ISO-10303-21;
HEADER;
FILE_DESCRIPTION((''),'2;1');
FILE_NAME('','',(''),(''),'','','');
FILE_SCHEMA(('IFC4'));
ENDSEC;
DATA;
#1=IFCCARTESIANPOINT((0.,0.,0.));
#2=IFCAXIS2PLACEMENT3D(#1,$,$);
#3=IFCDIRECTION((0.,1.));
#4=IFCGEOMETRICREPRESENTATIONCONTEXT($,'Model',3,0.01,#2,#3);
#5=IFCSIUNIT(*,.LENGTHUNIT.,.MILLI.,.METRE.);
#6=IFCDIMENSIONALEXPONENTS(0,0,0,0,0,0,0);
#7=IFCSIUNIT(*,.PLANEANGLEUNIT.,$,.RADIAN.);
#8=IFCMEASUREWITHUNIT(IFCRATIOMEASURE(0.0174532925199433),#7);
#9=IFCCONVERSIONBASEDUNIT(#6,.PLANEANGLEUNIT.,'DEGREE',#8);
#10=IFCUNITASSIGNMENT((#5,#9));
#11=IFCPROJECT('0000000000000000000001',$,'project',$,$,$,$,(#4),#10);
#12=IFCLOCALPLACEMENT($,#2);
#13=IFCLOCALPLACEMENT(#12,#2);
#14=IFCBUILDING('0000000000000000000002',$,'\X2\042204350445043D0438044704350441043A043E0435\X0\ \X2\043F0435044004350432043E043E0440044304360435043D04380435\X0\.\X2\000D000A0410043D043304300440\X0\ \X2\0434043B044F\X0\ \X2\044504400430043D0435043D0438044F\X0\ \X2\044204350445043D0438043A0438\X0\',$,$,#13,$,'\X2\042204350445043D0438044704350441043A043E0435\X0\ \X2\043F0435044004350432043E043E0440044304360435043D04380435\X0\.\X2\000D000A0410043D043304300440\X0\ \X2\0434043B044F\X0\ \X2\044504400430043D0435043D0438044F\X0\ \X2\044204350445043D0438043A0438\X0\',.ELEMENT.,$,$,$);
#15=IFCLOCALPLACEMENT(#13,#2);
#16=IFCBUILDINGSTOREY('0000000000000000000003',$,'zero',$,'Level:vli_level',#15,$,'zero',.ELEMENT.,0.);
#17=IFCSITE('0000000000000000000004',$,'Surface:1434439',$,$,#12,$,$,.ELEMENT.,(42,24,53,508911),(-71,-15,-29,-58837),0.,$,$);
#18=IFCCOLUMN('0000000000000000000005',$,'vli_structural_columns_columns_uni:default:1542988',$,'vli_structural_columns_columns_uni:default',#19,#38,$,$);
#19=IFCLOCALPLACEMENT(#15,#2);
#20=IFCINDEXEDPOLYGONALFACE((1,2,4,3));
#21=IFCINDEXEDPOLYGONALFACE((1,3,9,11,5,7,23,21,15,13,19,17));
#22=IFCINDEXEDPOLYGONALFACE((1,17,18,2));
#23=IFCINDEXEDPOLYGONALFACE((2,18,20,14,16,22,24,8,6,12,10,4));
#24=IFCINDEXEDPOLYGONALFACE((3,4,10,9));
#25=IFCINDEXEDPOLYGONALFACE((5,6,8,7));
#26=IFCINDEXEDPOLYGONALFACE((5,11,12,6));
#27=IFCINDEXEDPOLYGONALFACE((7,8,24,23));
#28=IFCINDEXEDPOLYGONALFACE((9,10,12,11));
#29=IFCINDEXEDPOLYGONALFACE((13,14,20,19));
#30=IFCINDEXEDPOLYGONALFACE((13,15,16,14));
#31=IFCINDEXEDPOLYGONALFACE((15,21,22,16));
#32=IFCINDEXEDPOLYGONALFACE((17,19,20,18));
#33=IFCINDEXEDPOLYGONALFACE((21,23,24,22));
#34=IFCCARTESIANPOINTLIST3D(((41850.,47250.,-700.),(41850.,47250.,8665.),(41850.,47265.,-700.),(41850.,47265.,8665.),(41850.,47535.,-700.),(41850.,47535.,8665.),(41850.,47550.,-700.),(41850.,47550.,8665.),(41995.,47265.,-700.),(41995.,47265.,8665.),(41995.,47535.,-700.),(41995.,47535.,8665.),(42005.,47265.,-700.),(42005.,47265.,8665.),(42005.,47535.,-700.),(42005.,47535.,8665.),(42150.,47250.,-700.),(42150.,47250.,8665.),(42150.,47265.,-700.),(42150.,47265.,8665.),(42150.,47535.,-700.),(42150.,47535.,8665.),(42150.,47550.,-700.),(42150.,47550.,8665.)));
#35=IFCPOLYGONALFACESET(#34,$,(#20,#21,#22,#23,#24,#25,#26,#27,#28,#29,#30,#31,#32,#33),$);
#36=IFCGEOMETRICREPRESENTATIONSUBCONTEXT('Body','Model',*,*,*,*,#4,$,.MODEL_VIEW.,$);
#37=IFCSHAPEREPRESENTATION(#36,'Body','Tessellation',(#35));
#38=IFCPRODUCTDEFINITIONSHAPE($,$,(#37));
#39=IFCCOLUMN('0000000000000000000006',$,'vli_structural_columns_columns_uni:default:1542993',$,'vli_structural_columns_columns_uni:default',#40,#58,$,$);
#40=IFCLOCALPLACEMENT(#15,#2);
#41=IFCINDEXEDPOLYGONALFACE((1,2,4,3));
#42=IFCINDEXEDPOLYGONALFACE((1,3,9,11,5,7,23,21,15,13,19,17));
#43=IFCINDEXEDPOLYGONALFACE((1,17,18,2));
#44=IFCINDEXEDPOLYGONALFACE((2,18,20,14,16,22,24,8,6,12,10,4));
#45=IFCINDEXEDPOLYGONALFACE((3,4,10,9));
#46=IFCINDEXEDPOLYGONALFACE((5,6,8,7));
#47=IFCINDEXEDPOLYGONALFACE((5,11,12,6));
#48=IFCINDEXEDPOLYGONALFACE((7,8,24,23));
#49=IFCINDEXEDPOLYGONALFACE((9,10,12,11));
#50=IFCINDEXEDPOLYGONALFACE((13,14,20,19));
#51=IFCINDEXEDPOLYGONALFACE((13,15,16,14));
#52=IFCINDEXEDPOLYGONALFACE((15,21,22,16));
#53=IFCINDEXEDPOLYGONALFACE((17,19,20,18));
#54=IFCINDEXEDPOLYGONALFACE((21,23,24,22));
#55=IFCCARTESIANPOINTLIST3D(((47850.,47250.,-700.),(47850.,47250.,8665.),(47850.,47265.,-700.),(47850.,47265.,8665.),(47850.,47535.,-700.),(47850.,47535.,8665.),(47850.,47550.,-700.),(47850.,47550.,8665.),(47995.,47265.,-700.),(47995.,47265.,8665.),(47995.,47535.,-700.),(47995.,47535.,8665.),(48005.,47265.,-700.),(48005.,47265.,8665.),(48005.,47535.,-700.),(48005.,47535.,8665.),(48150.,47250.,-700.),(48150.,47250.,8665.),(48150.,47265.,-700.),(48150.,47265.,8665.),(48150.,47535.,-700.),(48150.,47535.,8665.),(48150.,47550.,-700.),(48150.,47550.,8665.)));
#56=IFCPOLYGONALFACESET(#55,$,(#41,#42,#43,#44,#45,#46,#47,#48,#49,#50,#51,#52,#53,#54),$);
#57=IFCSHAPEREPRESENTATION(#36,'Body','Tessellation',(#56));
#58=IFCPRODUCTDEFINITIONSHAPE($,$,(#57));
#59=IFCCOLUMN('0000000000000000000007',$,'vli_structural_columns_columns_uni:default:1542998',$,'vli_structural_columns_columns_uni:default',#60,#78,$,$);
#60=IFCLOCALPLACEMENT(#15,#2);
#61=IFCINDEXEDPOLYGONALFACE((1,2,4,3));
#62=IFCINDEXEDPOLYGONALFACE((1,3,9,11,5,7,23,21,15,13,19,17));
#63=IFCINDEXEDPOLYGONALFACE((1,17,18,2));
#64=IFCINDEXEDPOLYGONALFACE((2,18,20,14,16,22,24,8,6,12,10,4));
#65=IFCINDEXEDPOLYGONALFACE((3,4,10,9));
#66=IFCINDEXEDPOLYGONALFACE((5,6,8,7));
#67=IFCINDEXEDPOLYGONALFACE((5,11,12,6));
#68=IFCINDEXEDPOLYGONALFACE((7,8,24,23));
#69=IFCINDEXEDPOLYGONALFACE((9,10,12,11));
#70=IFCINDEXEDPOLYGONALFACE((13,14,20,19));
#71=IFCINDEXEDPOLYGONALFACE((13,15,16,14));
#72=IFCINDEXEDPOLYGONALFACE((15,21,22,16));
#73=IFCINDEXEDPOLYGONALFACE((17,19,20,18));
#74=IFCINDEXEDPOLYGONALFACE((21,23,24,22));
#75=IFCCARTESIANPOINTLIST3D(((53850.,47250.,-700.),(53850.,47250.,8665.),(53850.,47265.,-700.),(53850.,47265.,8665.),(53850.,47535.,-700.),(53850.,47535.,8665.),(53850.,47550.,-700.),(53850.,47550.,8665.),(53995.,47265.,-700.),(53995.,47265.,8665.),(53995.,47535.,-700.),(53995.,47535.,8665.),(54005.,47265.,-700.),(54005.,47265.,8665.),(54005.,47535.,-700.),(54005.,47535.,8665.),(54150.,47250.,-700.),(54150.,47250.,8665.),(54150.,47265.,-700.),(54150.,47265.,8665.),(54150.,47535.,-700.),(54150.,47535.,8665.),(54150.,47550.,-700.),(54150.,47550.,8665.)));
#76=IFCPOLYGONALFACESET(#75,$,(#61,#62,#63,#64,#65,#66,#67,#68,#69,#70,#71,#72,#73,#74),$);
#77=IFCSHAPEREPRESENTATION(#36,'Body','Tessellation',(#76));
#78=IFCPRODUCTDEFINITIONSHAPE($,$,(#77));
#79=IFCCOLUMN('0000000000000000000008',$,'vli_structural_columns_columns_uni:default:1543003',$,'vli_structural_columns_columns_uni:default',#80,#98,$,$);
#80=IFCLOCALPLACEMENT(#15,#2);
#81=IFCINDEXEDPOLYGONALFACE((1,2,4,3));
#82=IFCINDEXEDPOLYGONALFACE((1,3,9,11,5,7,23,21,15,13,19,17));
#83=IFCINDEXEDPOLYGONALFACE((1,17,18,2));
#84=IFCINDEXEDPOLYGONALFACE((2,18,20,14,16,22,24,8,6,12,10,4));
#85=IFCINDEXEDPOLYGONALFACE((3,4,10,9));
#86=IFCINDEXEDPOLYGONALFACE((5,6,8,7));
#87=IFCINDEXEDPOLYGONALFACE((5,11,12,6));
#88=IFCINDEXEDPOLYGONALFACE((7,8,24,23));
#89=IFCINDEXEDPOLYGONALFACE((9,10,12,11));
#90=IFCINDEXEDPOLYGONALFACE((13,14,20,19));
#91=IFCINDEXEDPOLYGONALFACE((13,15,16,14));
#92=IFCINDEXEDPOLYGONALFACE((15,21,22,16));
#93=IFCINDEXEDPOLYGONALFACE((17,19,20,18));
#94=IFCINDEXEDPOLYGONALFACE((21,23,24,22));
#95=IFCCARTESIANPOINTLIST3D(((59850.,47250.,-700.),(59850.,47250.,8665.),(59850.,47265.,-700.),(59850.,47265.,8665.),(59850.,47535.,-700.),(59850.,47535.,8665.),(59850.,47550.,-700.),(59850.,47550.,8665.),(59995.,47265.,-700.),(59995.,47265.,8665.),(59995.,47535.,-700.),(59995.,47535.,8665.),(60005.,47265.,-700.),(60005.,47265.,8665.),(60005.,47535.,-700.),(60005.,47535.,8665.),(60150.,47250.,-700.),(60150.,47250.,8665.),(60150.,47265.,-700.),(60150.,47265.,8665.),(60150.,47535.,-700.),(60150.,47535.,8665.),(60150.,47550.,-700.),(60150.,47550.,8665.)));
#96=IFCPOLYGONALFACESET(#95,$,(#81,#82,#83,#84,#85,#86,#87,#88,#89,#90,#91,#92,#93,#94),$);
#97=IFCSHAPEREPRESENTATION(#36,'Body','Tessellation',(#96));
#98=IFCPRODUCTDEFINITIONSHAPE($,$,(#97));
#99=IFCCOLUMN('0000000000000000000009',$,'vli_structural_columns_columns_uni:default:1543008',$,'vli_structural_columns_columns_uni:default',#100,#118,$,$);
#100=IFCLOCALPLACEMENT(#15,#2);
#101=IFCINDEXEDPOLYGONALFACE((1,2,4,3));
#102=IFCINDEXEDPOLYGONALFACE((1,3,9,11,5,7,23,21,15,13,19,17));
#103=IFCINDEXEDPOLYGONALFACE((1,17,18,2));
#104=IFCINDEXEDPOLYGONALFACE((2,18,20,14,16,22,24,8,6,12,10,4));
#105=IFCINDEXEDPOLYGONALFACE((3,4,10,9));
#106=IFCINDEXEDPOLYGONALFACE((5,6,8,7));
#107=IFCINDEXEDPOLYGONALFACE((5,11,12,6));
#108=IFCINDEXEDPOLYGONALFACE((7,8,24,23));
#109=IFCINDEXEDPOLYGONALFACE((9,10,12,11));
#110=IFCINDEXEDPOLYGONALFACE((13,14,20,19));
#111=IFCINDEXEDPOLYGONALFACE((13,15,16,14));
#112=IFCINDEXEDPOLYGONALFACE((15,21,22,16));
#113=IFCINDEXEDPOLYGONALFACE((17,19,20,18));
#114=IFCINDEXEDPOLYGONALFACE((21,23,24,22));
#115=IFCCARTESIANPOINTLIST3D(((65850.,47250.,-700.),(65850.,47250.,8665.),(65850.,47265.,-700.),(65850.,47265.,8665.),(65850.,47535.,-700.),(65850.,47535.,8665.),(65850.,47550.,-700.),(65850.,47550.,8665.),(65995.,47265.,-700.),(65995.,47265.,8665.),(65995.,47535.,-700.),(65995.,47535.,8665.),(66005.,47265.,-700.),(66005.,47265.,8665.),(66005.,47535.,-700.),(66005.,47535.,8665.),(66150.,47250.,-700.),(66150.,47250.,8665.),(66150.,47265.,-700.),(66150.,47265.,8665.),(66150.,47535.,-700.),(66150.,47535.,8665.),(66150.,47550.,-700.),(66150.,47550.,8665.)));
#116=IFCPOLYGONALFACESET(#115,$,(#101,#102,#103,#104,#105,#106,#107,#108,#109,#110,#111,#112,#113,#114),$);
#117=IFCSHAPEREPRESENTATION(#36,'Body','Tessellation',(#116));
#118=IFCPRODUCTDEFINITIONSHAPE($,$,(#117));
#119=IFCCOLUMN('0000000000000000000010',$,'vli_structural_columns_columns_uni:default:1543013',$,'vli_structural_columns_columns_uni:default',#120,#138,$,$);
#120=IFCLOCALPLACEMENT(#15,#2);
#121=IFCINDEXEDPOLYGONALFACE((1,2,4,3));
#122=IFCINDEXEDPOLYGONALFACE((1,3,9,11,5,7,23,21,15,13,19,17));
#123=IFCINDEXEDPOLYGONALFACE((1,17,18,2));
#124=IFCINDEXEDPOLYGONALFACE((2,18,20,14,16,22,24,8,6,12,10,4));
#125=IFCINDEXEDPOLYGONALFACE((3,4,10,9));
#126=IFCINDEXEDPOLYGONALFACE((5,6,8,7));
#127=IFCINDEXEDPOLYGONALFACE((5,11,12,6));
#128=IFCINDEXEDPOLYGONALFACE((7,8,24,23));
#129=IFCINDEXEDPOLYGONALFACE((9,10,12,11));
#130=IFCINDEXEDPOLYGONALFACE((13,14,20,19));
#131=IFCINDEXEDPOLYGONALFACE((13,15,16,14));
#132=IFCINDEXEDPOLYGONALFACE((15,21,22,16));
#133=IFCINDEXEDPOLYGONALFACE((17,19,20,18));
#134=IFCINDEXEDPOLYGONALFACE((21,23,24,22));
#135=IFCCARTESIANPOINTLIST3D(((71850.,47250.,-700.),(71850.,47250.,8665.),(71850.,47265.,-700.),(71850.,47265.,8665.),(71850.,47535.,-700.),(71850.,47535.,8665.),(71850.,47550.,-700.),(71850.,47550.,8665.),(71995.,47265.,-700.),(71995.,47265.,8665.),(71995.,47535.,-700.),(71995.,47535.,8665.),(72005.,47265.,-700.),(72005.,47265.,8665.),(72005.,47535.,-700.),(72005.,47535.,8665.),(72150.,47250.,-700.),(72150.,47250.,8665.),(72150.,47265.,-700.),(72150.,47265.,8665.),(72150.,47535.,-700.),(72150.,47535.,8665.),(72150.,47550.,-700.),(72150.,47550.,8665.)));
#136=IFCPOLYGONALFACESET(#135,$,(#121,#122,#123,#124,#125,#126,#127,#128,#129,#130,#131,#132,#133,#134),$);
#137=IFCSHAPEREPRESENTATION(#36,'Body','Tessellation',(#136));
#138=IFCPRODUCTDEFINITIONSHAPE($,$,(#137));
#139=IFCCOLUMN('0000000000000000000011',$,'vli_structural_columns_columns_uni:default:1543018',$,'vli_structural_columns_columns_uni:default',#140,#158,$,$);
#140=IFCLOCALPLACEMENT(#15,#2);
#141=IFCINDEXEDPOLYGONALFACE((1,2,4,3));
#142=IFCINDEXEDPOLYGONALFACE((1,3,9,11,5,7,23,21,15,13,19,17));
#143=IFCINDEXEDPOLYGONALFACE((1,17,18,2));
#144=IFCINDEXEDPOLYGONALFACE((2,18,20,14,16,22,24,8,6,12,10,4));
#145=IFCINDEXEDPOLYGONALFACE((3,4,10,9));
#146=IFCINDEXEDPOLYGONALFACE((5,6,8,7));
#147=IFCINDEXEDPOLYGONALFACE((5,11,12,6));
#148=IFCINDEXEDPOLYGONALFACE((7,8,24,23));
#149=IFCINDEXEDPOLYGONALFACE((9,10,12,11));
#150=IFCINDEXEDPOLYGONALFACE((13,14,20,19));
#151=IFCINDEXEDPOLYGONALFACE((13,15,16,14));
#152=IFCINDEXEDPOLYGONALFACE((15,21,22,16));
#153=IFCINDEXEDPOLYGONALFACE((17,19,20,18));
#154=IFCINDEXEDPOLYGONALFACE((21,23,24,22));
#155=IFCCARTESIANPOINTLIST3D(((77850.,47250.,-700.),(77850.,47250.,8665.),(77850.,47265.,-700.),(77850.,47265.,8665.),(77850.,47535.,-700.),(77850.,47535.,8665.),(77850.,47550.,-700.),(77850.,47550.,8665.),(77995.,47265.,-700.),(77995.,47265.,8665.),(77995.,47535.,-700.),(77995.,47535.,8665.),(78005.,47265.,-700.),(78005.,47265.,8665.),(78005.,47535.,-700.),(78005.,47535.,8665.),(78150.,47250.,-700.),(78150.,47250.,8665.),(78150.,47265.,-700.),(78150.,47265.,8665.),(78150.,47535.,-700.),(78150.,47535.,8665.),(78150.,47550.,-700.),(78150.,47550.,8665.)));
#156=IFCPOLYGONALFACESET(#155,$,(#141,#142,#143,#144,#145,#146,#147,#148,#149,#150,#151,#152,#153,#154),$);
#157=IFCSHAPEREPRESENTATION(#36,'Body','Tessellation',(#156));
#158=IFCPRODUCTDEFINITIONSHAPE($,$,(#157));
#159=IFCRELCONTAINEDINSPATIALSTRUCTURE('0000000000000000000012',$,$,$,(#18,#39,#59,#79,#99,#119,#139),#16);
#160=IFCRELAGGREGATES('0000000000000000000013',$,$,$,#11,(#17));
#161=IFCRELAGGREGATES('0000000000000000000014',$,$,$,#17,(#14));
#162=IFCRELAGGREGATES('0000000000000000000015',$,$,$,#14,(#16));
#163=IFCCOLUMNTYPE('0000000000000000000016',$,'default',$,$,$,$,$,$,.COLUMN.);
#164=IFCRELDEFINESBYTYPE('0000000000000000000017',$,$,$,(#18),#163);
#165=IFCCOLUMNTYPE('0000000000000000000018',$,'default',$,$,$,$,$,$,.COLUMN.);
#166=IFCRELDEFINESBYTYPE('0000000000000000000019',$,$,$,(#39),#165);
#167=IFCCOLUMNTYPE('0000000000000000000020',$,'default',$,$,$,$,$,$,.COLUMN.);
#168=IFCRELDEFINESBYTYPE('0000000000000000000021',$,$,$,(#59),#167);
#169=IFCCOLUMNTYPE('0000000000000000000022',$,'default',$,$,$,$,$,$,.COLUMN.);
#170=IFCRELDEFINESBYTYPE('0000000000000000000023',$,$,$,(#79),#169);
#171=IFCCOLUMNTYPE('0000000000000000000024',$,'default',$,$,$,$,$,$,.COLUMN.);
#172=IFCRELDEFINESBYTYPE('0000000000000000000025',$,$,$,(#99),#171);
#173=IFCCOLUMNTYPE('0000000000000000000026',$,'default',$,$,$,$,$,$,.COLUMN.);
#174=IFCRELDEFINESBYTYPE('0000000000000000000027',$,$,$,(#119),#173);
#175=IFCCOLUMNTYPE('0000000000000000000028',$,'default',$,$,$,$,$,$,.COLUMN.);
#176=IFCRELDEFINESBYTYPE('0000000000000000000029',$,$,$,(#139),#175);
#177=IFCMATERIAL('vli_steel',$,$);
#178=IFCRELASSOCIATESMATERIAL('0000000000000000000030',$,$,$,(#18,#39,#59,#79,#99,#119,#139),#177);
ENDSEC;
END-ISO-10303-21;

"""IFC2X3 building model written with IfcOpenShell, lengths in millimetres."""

from ifc_helpers import new_model, entity, si_unit, converted_unit, direction, frame, origin, place, context, subcontext, project, spatial, polyline, outline, extrude, source, transform, mapped, material, type_object, type_shapes, element, save


model = new_model("IFC2X3")

# Units and contexts
model_context = context("Model", 3, precision=0.01, world=origin(), true_north=direction((0.0, 1.0)))
body_context = subcontext(model_context, "Body", "Model", "MODEL_VIEW")
ifc_project = project(units=[si_unit("LENGTHUNIT", "METRE", prefix="MILLI"), converted_unit("PLANEANGLEUNIT", "DEGREE", entity("IfcRatioMeasure", 0.0174532925199433), si_unit("PLANEANGLEUNIT", "RADIAN"), dimensions=[0, 0, 0, 0, 0, 0, 0])], contexts=[model_context])

# Site, building, storey
site_placement = place(None, origin())
site = spatial("IfcSite", under=ifc_project, at=site_placement, Name="Surface:1434439", CompositionType="ELEMENT", RefLatitude=(42, 24, 53, 508911), RefLongitude=(-71, -15, -29, -58837), RefElevation=0.0)
building_placement = place(site_placement, origin())
building = spatial("IfcBuilding", under=site, at=building_placement, Name="Техническое перевооружение.\r\nАнгар для хранения техники", LongName="Техническое перевооружение.\r\nАнгар для хранения техники", CompositionType="ELEMENT")
storey_placement = place(building_placement, origin())
storey = spatial("IfcBuildingStorey", under=building, at=storey_placement, Name="zero", ObjectType="Level:vli_level", LongName="zero", CompositionType="ELEMENT", Elevation=0.0)

# Columns
ifc_material_1 = material(Name="vli_steel")
column_type_1 = type_object("IfcColumnType", Name="default", PredefinedType="COLUMN")
shared_shape_1 = source(origin(), body_context, "Body", "SweptSolid", [
    extrude(outline(polyline([(135.0, -150.0), (150.0, -150.0), (150.0, 150.0), (135.0, 150.0), (135.0, 5.0), (-135.0, 5.0), (-135.0, 150.0), (-150.0, 150.0), (-150.0, -150.0), (-135.0, -150.0), (-135.0, -5.0), (135.0, -5.0), (135.0, -150.0)])), frame((42000.0, 47400.0, -700.0), z_axis=(0.0, 0.0, 1.0), x_axis=(0.0, -1.0, 0.0)), (0.0, 0.0, 1.0), 9365.0),
])
type_shapes(column_type_1, [shared_shape_1])
column_1_placement = place(storey_placement, origin())
element("IfcColumn", 1, at=column_1_placement, inside=storey, type_object=column_type_1, material=ifc_material_1, Name="vli_structural_columns_columns_uni:default:1542988", ObjectType="vli_structural_columns_columns_uni:default", context=body_context, shape_type="MappedRepresentation", body=[
    mapped(shared_shape_1, transform((0.0, 0.0, 0.0), scale=1.0)),
])
column_type_2 = type_object("IfcColumnType", Name="default", PredefinedType="COLUMN")
shared_shape_2 = source(origin(), body_context, "Body", "SweptSolid", [
    extrude(outline(polyline([(135.0, -150.0), (150.0, -150.0), (150.0, 150.0), (135.0, 150.0), (135.0, 5.0), (-135.0, 5.0), (-135.0, 150.0), (-150.0, 150.0), (-150.0, -150.0), (-135.0, -150.0), (-135.0, -5.0), (135.0, -5.0), (135.0, -150.0)])), frame((48000.0, 47400.0, -700.0), z_axis=(0.0, 0.0, 1.0), x_axis=(0.0, -1.0, 0.0)), (0.0, 0.0, 1.0), 9365.0),
])
type_shapes(column_type_2, [shared_shape_2])
column_2_placement = place(storey_placement, origin())
element("IfcColumn", 2, at=column_2_placement, inside=storey, type_object=column_type_2, material=ifc_material_1, Name="vli_structural_columns_columns_uni:default:1542993", ObjectType="vli_structural_columns_columns_uni:default", context=body_context, shape_type="MappedRepresentation", body=[
    mapped(shared_shape_2, transform((0.0, 0.0, 0.0), scale=1.0)),
])
column_type_3 = type_object("IfcColumnType", Name="default", PredefinedType="COLUMN")
shared_shape_3 = source(origin(), body_context, "Body", "SweptSolid", [
    extrude(outline(polyline([(135.0, -150.0), (150.0, -150.0), (150.0, 150.0), (135.0, 150.0), (135.0, 5.0), (-135.0, 5.0), (-135.0, 150.0), (-150.0, 150.0), (-150.0, -150.0), (-135.0, -150.0), (-135.0, -5.0), (135.0, -5.0), (135.0, -150.0)])), frame((54000.0, 47400.0, -700.0), z_axis=(0.0, 0.0, 1.0), x_axis=(0.0, -1.0, 0.0)), (0.0, 0.0, 1.0), 9365.0),
])
type_shapes(column_type_3, [shared_shape_3])
column_3_placement = place(storey_placement, origin())
element("IfcColumn", 3, at=column_3_placement, inside=storey, type_object=column_type_3, material=ifc_material_1, Name="vli_structural_columns_columns_uni:default:1542998", ObjectType="vli_structural_columns_columns_uni:default", context=body_context, shape_type="MappedRepresentation", body=[
    mapped(shared_shape_3, transform((0.0, 0.0, 0.0), scale=1.0)),
])
column_type_4 = type_object("IfcColumnType", Name="default", PredefinedType="COLUMN")
shared_shape_4 = source(origin(), body_context, "Body", "SweptSolid", [
    extrude(outline(polyline([(135.0, -150.0), (150.0, -150.0), (150.0, 150.0), (135.0, 150.0), (135.0, 5.0), (-135.0, 5.0), (-135.0, 150.0), (-150.0, 150.0), (-150.0, -150.0), (-135.0, -150.0), (-135.0, -5.0), (135.0, -5.0), (135.0, -150.0)])), frame((60000.0, 47400.0, -700.0), z_axis=(0.0, 0.0, 1.0), x_axis=(0.0, -1.0, 0.0)), (0.0, 0.0, 1.0), 9365.0),
])
type_shapes(column_type_4, [shared_shape_4])
column_4_placement = place(storey_placement, origin())
element("IfcColumn", 4, at=column_4_placement, inside=storey, type_object=column_type_4, material=ifc_material_1, Name="vli_structural_columns_columns_uni:default:1543003", ObjectType="vli_structural_columns_columns_uni:default", context=body_context, shape_type="MappedRepresentation", body=[
    mapped(shared_shape_4, transform((0.0, 0.0, 0.0), scale=1.0)),
])
column_type_5 = type_object("IfcColumnType", Name="default", PredefinedType="COLUMN")
shared_shape_5 = source(origin(), body_context, "Body", "SweptSolid", [
    extrude(outline(polyline([(135.0, -150.0), (150.0, -150.0), (150.0, 150.0), (135.0, 150.0), (135.0, 5.0), (-135.0, 5.0), (-135.0, 150.0), (-150.0, 150.0), (-150.0, -150.0), (-135.0, -150.0), (-135.0, -5.0), (135.0, -5.0), (135.0, -150.0)])), frame((66000.0, 47400.0, -700.0), z_axis=(0.0, 0.0, 1.0), x_axis=(0.0, -1.0, 0.0)), (0.0, 0.0, 1.0), 9365.0),
])
type_shapes(column_type_5, [shared_shape_5])
column_5_placement = place(storey_placement, origin())
element("IfcColumn", 5, at=column_5_placement, inside=storey, type_object=column_type_5, material=ifc_material_1, Name="vli_structural_columns_columns_uni:default:1543008", ObjectType="vli_structural_columns_columns_uni:default", context=body_context, shape_type="MappedRepresentation", body=[
    mapped(shared_shape_5, transform((0.0, 0.0, 0.0), scale=1.0)),
])
column_type_6 = type_object("IfcColumnType", Name="default", PredefinedType="COLUMN")
shared_shape_6 = source(origin(), body_context, "Body", "SweptSolid", [
    extrude(outline(polyline([(135.0, -150.0), (150.0, -150.0), (150.0, 150.0), (135.0, 150.0), (135.0, 5.0), (-135.0, 5.0), (-135.0, 150.0), (-150.0, 150.0), (-150.0, -150.0), (-135.0, -150.0), (-135.0, -5.0), (135.0, -5.0), (135.0, -150.0)])), frame((72000.0, 47400.0, -700.0), z_axis=(0.0, 0.0, 1.0), x_axis=(0.0, -1.0, 0.0)), (0.0, 0.0, 1.0), 9365.0),
])
type_shapes(column_type_6, [shared_shape_6])
column_6_placement = place(storey_placement, origin())
element("IfcColumn", 6, at=column_6_placement, inside=storey, type_object=column_type_6, material=ifc_material_1, Name="vli_structural_columns_columns_uni:default:1543013", ObjectType="vli_structural_columns_columns_uni:default", context=body_context, shape_type="MappedRepresentation", body=[
    mapped(shared_shape_6, transform((0.0, 0.0, 0.0), scale=1.0)),
])
column_type_7 = type_object("IfcColumnType", Name="default", PredefinedType="COLUMN")
shared_shape_7 = source(origin(), body_context, "Body", "SweptSolid", [
    extrude(outline(polyline([(135.0, -150.0), (150.0, -150.0), (150.0, 150.0), (135.0, 150.0), (135.0, 5.0), (-135.0, 5.0), (-135.0, 150.0), (-150.0, 150.0), (-150.0, -150.0), (-135.0, -150.0), (-135.0, -5.0), (135.0, -5.0), (135.0, -150.0)])), frame((78000.0, 47400.0, -700.0), z_axis=(0.0, 0.0, 1.0), x_axis=(0.0, -1.0, 0.0)), (0.0, 0.0, 1.0), 9365.0),
])
type_shapes(column_type_7, [shared_shape_7])
column_7_placement = place(storey_placement, origin())
element("IfcColumn", 7, at=column_7_placement, inside=storey, type_object=column_type_7, material=ifc_material_1, Name="vli_structural_columns_columns_uni:default:1543018", ObjectType="vli_structural_columns_columns_uni:default", context=body_context, shape_type="MappedRepresentation", body=[
    mapped(shared_shape_7, transform((0.0, 0.0, 0.0), scale=1.0)),
])

save(model, "model.ifc")
